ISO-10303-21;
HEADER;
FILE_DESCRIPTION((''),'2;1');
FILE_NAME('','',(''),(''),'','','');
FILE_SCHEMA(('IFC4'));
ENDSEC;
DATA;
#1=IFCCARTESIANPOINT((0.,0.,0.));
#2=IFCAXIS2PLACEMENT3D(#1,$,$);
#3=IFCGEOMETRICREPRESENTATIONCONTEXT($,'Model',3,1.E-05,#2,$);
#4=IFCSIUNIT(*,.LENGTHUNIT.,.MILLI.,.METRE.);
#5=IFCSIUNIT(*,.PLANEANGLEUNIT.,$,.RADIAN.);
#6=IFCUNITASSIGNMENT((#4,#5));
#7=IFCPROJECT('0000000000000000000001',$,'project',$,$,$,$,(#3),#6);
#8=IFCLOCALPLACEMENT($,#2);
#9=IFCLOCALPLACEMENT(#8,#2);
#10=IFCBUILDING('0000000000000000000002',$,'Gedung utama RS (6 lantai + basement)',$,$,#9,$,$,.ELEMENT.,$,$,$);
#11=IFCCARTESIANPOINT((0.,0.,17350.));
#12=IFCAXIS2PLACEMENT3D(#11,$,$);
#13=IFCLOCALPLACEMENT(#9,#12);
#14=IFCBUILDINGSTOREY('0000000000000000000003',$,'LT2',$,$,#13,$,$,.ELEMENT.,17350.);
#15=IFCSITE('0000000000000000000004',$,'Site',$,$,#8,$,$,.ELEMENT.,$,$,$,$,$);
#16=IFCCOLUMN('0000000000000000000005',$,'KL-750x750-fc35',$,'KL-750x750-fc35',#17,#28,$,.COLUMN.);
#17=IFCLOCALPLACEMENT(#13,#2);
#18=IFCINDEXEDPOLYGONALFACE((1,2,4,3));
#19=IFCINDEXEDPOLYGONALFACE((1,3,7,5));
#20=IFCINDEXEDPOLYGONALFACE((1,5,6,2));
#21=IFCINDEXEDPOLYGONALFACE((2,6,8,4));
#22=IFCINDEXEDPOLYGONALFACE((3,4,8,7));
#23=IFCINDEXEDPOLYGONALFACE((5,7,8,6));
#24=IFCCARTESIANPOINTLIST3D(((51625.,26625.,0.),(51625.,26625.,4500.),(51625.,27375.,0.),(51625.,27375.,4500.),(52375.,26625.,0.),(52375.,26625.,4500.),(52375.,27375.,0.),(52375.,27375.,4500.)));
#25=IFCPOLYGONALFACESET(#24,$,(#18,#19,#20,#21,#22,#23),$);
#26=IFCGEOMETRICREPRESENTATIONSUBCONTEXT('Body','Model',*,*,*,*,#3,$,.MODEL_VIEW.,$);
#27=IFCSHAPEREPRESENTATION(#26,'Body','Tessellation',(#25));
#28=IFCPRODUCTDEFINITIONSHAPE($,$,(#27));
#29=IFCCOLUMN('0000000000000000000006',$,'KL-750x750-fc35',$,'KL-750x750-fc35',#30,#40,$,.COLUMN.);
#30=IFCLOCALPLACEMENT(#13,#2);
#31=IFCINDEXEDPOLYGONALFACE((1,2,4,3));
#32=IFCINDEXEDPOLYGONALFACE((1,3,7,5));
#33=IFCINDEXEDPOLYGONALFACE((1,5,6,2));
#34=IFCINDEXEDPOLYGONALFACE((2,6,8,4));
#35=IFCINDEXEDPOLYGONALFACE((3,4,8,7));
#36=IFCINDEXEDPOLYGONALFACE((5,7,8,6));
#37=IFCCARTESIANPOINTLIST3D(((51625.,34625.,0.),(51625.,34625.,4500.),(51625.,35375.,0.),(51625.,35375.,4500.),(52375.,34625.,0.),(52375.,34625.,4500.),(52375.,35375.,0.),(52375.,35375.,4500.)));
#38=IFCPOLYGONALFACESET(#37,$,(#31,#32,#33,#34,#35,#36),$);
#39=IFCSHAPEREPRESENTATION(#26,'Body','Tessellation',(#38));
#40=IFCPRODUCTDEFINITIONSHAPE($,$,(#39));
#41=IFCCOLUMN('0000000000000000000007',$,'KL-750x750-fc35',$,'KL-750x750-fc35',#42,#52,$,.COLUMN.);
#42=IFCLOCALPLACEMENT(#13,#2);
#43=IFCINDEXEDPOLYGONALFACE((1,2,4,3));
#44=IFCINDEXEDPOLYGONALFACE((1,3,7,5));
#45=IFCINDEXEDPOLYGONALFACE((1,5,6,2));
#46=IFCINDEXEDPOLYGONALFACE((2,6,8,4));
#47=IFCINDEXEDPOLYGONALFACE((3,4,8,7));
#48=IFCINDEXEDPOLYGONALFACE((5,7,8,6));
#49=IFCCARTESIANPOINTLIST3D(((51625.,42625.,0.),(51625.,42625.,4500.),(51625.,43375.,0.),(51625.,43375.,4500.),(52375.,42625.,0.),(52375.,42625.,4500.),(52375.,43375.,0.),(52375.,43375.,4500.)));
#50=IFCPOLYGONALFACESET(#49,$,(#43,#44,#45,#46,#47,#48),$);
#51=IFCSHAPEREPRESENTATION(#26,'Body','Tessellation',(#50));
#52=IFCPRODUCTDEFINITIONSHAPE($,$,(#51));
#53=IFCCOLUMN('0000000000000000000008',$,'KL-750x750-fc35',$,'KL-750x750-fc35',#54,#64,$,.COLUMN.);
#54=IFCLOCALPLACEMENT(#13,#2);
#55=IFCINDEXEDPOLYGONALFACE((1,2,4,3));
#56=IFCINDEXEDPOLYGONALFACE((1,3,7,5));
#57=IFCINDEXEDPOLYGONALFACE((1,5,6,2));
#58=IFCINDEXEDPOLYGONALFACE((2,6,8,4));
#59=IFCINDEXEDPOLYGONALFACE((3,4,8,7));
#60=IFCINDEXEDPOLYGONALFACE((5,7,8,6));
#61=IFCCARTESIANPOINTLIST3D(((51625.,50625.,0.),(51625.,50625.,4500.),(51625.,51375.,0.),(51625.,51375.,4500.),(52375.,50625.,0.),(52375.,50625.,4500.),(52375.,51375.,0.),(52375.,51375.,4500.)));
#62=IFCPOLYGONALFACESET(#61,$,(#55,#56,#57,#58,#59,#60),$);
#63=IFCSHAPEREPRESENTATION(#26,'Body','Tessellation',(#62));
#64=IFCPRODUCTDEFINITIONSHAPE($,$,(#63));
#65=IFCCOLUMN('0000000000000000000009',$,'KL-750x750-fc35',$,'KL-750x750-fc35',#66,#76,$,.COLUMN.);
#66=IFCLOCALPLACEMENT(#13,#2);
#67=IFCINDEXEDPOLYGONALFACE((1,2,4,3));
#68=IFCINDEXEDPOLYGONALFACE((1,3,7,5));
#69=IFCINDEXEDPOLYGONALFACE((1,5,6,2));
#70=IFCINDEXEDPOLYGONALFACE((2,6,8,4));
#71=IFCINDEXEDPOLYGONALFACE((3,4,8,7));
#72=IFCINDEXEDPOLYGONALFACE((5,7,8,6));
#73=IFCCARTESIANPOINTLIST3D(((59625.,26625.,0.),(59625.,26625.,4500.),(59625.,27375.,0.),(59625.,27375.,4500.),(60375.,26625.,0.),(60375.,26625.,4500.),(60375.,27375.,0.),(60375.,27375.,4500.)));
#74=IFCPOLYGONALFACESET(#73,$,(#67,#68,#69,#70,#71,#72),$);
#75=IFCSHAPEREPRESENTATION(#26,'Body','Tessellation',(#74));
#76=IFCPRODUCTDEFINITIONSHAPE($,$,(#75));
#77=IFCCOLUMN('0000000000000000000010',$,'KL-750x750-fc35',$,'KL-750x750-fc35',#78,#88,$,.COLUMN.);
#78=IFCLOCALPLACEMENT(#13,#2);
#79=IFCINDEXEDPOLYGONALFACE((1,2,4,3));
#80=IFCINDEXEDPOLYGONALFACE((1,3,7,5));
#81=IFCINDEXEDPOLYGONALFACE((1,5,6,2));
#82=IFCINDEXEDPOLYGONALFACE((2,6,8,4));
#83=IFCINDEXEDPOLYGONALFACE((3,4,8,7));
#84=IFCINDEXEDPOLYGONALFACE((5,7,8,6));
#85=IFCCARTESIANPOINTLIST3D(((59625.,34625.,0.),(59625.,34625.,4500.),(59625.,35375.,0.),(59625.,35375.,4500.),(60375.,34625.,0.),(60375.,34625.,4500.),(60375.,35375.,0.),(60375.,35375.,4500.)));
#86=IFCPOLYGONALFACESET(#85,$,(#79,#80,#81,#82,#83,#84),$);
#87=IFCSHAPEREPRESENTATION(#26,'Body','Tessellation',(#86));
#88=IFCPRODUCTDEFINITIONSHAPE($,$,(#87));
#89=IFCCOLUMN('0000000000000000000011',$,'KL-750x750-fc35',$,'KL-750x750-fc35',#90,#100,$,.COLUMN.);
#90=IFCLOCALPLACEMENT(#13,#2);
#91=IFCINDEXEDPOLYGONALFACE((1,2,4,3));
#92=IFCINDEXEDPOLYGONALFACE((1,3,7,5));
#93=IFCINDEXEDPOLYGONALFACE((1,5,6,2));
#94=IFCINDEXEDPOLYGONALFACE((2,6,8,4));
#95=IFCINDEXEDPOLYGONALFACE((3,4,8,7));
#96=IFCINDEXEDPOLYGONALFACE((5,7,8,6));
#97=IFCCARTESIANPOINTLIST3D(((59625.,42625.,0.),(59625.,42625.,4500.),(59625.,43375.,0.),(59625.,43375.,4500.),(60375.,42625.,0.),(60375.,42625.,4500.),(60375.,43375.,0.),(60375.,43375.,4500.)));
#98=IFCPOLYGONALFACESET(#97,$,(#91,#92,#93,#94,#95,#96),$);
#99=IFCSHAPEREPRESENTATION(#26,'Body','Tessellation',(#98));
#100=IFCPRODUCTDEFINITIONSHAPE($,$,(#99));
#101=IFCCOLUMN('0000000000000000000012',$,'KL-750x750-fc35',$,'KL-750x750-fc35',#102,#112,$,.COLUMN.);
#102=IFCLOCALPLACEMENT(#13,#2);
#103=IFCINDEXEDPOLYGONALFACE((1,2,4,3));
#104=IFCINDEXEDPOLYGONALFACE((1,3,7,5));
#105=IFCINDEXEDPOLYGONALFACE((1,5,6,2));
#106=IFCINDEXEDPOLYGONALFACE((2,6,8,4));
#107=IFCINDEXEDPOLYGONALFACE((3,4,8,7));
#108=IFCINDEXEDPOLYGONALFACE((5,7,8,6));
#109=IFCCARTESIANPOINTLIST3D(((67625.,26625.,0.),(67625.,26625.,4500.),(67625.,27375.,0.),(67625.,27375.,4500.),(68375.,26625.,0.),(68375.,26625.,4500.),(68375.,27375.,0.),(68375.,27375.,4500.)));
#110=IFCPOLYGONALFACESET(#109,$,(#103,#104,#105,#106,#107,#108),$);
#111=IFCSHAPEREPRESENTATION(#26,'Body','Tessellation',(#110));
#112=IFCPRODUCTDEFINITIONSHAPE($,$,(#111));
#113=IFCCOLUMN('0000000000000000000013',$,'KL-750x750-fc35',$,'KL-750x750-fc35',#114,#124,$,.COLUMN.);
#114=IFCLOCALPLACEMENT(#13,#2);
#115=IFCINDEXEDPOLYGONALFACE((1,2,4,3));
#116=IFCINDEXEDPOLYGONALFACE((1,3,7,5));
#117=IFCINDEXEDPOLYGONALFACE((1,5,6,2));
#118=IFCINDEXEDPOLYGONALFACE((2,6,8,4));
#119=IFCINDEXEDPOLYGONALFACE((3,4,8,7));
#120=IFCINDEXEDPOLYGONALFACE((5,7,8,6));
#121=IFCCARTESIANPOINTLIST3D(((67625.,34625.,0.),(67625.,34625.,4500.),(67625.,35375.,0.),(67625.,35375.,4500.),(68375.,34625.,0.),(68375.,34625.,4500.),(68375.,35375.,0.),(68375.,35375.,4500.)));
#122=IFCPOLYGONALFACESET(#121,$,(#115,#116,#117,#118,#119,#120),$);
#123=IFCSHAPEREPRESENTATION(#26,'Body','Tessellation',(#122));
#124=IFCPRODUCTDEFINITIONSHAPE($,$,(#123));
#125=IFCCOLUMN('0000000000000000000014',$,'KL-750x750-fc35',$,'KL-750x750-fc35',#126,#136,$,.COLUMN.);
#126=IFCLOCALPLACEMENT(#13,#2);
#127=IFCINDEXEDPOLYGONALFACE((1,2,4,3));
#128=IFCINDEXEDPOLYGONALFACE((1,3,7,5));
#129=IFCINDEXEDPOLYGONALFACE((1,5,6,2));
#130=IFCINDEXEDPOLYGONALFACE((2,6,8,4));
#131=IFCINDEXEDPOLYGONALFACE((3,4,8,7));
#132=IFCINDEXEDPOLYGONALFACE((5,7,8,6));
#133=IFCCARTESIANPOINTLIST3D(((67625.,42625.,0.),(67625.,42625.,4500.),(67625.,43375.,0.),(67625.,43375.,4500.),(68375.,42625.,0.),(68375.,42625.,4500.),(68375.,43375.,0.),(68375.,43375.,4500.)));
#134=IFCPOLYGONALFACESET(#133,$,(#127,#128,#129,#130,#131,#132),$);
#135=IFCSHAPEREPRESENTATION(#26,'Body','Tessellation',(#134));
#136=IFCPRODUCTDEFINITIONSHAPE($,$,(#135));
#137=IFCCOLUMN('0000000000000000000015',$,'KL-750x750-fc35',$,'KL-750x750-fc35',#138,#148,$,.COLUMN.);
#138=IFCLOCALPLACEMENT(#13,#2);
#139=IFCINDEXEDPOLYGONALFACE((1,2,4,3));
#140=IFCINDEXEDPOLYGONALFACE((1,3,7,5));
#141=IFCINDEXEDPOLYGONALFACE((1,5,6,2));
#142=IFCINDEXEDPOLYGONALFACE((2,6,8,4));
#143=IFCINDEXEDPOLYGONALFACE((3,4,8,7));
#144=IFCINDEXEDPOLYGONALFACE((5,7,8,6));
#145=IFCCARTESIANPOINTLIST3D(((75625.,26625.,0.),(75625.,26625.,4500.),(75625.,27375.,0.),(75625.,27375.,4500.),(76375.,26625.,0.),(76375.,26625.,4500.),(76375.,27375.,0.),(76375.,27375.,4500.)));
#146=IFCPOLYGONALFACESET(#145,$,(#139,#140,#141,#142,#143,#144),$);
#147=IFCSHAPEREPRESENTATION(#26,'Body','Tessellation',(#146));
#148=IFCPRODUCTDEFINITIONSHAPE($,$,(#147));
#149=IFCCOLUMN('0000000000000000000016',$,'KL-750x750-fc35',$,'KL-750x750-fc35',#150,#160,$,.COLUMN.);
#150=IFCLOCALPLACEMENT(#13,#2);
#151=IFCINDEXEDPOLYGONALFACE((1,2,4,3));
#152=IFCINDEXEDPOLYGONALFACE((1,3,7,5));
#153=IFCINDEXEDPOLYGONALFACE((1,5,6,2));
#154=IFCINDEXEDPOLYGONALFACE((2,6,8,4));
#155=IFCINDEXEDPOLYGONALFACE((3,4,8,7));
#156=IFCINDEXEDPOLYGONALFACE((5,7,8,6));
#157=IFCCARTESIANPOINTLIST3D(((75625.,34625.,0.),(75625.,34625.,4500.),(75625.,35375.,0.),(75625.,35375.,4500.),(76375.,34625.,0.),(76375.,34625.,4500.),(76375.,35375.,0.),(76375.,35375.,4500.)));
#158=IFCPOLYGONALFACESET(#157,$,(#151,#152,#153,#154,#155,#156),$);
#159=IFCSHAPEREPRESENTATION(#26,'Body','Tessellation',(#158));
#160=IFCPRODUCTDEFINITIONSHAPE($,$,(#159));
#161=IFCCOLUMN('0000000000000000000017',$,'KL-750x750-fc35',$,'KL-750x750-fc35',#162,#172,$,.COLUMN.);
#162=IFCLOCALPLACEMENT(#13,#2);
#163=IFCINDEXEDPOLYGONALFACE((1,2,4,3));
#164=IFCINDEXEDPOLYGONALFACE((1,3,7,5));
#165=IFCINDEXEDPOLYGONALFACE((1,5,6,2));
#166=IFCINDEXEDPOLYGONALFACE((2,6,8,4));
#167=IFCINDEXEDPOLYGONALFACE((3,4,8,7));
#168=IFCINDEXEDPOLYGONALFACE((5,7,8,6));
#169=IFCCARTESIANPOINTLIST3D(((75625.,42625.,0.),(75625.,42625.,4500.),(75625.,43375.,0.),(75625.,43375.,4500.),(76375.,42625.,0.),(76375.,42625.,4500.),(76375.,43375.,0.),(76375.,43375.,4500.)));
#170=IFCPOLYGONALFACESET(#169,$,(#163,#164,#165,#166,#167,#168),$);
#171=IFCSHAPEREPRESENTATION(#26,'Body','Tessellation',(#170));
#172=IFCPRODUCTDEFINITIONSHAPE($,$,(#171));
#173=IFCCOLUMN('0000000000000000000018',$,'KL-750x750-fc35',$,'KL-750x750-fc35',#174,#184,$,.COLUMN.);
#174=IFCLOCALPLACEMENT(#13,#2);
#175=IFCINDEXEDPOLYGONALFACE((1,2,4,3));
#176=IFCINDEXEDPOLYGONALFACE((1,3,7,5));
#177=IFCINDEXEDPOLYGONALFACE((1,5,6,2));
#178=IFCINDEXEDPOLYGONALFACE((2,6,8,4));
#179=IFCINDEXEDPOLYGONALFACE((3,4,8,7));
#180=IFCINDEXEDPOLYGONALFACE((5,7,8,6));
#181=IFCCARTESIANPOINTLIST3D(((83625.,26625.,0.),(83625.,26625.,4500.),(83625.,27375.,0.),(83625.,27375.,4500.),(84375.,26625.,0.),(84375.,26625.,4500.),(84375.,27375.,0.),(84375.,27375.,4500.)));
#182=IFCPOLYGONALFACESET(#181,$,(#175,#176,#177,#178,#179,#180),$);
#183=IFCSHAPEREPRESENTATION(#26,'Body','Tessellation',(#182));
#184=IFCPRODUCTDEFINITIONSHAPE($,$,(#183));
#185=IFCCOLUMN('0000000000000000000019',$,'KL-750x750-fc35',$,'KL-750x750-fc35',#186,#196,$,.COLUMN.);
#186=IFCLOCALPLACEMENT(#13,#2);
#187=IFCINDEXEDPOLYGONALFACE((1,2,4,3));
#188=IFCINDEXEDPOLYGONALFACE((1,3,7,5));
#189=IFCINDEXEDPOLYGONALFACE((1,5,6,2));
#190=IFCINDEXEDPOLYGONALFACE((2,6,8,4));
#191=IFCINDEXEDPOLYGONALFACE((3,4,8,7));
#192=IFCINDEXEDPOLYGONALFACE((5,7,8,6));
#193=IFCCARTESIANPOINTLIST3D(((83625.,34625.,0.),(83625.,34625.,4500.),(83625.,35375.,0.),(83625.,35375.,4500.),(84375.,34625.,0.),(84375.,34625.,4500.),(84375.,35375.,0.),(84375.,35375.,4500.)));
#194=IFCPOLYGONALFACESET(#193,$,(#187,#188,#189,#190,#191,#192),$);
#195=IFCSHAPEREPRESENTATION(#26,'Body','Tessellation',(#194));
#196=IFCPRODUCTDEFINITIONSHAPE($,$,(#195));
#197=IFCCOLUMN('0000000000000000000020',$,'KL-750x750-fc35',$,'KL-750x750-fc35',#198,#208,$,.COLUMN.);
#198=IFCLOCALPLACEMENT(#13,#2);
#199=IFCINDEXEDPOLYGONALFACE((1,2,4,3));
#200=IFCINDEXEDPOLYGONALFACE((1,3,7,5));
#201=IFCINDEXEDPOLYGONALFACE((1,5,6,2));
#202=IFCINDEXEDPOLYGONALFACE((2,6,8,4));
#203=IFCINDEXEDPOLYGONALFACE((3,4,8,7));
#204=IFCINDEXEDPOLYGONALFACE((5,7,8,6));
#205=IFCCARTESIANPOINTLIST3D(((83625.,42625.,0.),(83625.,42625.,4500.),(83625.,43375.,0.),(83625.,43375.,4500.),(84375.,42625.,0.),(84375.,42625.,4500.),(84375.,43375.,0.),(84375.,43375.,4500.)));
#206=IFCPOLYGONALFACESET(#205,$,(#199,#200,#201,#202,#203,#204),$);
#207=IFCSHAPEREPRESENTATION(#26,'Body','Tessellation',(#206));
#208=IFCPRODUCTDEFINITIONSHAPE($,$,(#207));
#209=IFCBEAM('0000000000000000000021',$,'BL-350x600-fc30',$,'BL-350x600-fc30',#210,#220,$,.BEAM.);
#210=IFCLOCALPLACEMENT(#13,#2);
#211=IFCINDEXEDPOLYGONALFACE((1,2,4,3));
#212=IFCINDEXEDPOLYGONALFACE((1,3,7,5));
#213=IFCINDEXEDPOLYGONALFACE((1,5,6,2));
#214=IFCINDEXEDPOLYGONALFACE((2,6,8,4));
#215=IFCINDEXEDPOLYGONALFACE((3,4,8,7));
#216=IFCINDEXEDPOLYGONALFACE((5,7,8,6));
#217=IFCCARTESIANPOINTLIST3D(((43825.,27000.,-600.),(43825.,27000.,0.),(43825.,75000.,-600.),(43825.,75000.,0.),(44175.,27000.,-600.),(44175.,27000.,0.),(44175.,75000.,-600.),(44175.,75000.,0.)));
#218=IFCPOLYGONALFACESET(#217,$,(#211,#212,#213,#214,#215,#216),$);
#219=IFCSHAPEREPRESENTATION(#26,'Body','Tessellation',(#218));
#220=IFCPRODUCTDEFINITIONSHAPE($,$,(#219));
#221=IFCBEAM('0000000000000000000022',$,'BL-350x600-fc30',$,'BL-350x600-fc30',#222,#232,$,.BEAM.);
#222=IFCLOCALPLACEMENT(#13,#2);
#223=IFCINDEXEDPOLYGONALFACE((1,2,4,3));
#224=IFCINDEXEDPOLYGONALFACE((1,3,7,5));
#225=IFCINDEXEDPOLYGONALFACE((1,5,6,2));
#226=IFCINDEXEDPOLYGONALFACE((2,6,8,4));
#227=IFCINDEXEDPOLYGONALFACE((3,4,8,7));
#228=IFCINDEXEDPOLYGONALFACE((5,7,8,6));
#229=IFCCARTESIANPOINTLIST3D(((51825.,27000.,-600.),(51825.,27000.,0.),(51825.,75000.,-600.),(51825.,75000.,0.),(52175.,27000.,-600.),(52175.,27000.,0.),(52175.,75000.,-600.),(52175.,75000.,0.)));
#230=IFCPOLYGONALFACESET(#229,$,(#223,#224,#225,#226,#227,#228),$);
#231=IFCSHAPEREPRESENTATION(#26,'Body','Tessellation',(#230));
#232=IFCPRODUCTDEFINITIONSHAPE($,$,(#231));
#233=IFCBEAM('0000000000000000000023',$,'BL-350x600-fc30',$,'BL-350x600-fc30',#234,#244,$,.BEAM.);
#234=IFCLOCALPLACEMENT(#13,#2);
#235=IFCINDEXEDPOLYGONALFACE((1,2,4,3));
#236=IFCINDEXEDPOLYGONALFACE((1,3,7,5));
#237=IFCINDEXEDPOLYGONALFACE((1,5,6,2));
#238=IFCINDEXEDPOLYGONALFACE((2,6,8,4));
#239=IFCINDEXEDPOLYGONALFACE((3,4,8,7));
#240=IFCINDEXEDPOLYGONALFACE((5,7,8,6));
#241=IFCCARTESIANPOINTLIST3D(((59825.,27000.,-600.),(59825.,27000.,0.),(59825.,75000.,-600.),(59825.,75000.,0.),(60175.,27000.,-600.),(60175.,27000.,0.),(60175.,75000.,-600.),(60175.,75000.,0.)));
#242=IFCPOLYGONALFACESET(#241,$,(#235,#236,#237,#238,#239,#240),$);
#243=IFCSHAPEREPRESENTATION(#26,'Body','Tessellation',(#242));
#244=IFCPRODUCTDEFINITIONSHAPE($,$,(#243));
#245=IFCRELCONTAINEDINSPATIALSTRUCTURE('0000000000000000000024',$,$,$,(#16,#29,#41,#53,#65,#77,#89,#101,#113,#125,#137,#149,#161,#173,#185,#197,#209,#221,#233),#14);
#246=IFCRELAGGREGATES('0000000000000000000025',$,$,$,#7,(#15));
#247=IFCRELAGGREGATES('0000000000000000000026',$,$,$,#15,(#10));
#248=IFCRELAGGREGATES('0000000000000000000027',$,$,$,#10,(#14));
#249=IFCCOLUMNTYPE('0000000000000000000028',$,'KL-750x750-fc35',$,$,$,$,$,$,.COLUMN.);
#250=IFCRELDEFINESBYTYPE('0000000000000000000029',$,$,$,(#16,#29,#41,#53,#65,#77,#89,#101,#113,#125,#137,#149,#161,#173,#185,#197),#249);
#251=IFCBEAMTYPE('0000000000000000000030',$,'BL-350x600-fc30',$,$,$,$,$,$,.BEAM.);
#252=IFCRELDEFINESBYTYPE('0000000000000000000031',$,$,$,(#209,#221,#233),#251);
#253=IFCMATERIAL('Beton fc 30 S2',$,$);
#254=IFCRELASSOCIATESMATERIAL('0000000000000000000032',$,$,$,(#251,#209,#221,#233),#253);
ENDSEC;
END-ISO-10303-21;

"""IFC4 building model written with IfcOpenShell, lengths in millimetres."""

from ifc_helpers import new_model, si_unit, frame, origin, origin_2d, place, context, subcontext, project, spatial, rectangle, extrude, material, material_profile, profile_set, profile_usage, type_object, element, save


model = new_model("IFC4")

# Units and contexts
model_context = context("Model", 3, precision=1e-05, world=origin())
body_context = subcontext(model_context, "Body", "Model", "MODEL_VIEW")
ifc_project = project(units=[si_unit("LENGTHUNIT", "METRE", prefix="MILLI"), si_unit("PLANEANGLEUNIT", "RADIAN")], contexts=[model_context])

# Site, building, storey
site_placement = place(None, origin())
site = spatial("IfcSite", under=ifc_project, at=site_placement, Name="Site", CompositionType="ELEMENT")
building_placement = place(site_placement, origin())
building = spatial("IfcBuilding", under=site, at=building_placement, Name="Gedung utama RS (6 lantai + basement)", CompositionType="ELEMENT")
storey_placement = place(building_placement, frame((0.0, 0.0, 17350.0)))
storey = spatial("IfcBuildingStorey", under=building, at=storey_placement, Name="LT2", CompositionType="ELEMENT", Elevation=17350.0)

# Columns
ifc_material_profile_1 = material_profile(None, rectangle(XDim=750.0, YDim=750.0, at=origin_2d()), Name="KL-750x750-fc35")
ifc_profile_set_1 = profile_set([ifc_material_profile_1], Name="KL-750x750-fc35")
ifc_profile_usage_1 = profile_usage(ifc_profile_set_1, cardinal=5)
column_type = type_object("IfcColumnType", Name="KL-750x750-fc35", PredefinedType="COLUMN", material=ifc_profile_set_1)
for number, where, z_axis, x_axis, name in (
    (1, (52000.0, 27000.0, 0.0), (0.0, 0.0, 1.0), (1.0, 0.0, 0.0), "KL-750x750-fc35"),
    (2, (52000.0, 35000.0, 0.0), (0.0, 0.0, 1.0), (1.0, 0.0, 0.0), "KL-750x750-fc35"),
    (3, (52000.0, 43000.0, 0.0), (0.0, 0.0, 1.0), (1.0, 0.0, 0.0), "KL-750x750-fc35"),
    (4, (52000.0, 51000.0, 0.0), (0.0, 0.0, 1.0), (1.0, 0.0, 0.0), "KL-750x750-fc35"),
    (5, (60000.0, 27000.0, 0.0), (0.0, 0.0, 1.0), (1.0, 0.0, 0.0), "KL-750x750-fc35"),
    (6, (60000.0, 35000.0, 0.0), (0.0, 0.0, 1.0), (1.0, 0.0, 0.0), "KL-750x750-fc35"),
    (7, (60000.0, 43000.0, 0.0), (0.0, 0.0, 1.0), (1.0, 0.0, 0.0), "KL-750x750-fc35"),
    (8, (68000.0, 27000.0, 0.0), (0.0, 0.0, 1.0), (1.0, 0.0, 0.0), "KL-750x750-fc35"),
    (9, (68000.0, 35000.0, 0.0), (0.0, 0.0, 1.0), (1.0, 0.0, 0.0), "KL-750x750-fc35"),
    (10, (68000.0, 43000.0, 0.0), (0.0, 0.0, 1.0), (1.0, 0.0, 0.0), "KL-750x750-fc35"),
    (11, (76000.0, 27000.0, 0.0), (0.0, 0.0, 1.0), (1.0, 0.0, 0.0), "KL-750x750-fc35"),
    (12, (76000.0, 35000.0, 0.0), (0.0, 0.0, 1.0), (1.0, 0.0, 0.0), "KL-750x750-fc35"),
    (13, (76000.0, 43000.0, 0.0), (0.0, 0.0, 1.0), (1.0, 0.0, 0.0), "KL-750x750-fc35"),
    (14, (84000.0, 27000.0, 0.0), (0.0, 0.0, 1.0), (1.0, 0.0, 0.0), "KL-750x750-fc35"),
    (15, (84000.0, 35000.0, 0.0), (0.0, 0.0, 1.0), (1.0, 0.0, 0.0), "KL-750x750-fc35"),
    (16, (84000.0, 43000.0, 0.0), (0.0, 0.0, 1.0), (1.0, 0.0, 0.0), "KL-750x750-fc35"),
):
    element("IfcColumn", number, at=place(storey_placement, frame(where, z_axis=z_axis, x_axis=x_axis)), inside=storey, type_object=column_type, material=ifc_profile_usage_1, Name=name, ObjectType="KL-750x750-fc35", PredefinedType="COLUMN", context=body_context, shape_type="SweptSolid", body=[
        extrude(rectangle(XDim=750.0, YDim=750.0, at=origin_2d()), origin(), (0.0, 0.0, 1.0), 4500.0),
    ])

# Beams
ifc_material = material(Name="Beton fc 30 S2")
ifc_material_profile_2 = material_profile(ifc_material, rectangle(XDim=350.0, YDim=600.0, at=origin_2d()), Name="BL-350x600-fc30")
ifc_profile_set_2 = profile_set([ifc_material_profile_2], Name="BL-350x600-fc30")
ifc_profile_usage_2 = profile_usage(ifc_profile_set_2, cardinal=8)
beam_type = type_object("IfcBeamType", Name="BL-350x600-fc30", PredefinedType="BEAM", material=ifc_profile_set_2)
for number, where, name in (
    (17, (44000.0, 27000.0, -300.0), "BL-350x600-fc30"),
    (18, (52000.0, 27000.0, -300.0), "BL-350x600-fc30"),
    (19, (60000.0, 27000.0, -300.0), "BL-350x600-fc30"),
):
    element("IfcBeam", number, at=place(storey_placement, frame(where)), inside=storey, type_object=beam_type, material=ifc_profile_usage_2, Name=name, ObjectType="BL-350x600-fc30", PredefinedType="BEAM", context=body_context, shape_type="SweptSolid", body=[
        extrude(rectangle(XDim=350.0, YDim=600.0, at=origin_2d()), frame((0.0, 0.0, 0.0), z_axis=(0.0, 1.0, 0.0), x_axis=(-1.0, 0.0, 0.0)), (0.0, 0.0, 1.0), 48000.0),
    ])

save(model, "model.ifc")
